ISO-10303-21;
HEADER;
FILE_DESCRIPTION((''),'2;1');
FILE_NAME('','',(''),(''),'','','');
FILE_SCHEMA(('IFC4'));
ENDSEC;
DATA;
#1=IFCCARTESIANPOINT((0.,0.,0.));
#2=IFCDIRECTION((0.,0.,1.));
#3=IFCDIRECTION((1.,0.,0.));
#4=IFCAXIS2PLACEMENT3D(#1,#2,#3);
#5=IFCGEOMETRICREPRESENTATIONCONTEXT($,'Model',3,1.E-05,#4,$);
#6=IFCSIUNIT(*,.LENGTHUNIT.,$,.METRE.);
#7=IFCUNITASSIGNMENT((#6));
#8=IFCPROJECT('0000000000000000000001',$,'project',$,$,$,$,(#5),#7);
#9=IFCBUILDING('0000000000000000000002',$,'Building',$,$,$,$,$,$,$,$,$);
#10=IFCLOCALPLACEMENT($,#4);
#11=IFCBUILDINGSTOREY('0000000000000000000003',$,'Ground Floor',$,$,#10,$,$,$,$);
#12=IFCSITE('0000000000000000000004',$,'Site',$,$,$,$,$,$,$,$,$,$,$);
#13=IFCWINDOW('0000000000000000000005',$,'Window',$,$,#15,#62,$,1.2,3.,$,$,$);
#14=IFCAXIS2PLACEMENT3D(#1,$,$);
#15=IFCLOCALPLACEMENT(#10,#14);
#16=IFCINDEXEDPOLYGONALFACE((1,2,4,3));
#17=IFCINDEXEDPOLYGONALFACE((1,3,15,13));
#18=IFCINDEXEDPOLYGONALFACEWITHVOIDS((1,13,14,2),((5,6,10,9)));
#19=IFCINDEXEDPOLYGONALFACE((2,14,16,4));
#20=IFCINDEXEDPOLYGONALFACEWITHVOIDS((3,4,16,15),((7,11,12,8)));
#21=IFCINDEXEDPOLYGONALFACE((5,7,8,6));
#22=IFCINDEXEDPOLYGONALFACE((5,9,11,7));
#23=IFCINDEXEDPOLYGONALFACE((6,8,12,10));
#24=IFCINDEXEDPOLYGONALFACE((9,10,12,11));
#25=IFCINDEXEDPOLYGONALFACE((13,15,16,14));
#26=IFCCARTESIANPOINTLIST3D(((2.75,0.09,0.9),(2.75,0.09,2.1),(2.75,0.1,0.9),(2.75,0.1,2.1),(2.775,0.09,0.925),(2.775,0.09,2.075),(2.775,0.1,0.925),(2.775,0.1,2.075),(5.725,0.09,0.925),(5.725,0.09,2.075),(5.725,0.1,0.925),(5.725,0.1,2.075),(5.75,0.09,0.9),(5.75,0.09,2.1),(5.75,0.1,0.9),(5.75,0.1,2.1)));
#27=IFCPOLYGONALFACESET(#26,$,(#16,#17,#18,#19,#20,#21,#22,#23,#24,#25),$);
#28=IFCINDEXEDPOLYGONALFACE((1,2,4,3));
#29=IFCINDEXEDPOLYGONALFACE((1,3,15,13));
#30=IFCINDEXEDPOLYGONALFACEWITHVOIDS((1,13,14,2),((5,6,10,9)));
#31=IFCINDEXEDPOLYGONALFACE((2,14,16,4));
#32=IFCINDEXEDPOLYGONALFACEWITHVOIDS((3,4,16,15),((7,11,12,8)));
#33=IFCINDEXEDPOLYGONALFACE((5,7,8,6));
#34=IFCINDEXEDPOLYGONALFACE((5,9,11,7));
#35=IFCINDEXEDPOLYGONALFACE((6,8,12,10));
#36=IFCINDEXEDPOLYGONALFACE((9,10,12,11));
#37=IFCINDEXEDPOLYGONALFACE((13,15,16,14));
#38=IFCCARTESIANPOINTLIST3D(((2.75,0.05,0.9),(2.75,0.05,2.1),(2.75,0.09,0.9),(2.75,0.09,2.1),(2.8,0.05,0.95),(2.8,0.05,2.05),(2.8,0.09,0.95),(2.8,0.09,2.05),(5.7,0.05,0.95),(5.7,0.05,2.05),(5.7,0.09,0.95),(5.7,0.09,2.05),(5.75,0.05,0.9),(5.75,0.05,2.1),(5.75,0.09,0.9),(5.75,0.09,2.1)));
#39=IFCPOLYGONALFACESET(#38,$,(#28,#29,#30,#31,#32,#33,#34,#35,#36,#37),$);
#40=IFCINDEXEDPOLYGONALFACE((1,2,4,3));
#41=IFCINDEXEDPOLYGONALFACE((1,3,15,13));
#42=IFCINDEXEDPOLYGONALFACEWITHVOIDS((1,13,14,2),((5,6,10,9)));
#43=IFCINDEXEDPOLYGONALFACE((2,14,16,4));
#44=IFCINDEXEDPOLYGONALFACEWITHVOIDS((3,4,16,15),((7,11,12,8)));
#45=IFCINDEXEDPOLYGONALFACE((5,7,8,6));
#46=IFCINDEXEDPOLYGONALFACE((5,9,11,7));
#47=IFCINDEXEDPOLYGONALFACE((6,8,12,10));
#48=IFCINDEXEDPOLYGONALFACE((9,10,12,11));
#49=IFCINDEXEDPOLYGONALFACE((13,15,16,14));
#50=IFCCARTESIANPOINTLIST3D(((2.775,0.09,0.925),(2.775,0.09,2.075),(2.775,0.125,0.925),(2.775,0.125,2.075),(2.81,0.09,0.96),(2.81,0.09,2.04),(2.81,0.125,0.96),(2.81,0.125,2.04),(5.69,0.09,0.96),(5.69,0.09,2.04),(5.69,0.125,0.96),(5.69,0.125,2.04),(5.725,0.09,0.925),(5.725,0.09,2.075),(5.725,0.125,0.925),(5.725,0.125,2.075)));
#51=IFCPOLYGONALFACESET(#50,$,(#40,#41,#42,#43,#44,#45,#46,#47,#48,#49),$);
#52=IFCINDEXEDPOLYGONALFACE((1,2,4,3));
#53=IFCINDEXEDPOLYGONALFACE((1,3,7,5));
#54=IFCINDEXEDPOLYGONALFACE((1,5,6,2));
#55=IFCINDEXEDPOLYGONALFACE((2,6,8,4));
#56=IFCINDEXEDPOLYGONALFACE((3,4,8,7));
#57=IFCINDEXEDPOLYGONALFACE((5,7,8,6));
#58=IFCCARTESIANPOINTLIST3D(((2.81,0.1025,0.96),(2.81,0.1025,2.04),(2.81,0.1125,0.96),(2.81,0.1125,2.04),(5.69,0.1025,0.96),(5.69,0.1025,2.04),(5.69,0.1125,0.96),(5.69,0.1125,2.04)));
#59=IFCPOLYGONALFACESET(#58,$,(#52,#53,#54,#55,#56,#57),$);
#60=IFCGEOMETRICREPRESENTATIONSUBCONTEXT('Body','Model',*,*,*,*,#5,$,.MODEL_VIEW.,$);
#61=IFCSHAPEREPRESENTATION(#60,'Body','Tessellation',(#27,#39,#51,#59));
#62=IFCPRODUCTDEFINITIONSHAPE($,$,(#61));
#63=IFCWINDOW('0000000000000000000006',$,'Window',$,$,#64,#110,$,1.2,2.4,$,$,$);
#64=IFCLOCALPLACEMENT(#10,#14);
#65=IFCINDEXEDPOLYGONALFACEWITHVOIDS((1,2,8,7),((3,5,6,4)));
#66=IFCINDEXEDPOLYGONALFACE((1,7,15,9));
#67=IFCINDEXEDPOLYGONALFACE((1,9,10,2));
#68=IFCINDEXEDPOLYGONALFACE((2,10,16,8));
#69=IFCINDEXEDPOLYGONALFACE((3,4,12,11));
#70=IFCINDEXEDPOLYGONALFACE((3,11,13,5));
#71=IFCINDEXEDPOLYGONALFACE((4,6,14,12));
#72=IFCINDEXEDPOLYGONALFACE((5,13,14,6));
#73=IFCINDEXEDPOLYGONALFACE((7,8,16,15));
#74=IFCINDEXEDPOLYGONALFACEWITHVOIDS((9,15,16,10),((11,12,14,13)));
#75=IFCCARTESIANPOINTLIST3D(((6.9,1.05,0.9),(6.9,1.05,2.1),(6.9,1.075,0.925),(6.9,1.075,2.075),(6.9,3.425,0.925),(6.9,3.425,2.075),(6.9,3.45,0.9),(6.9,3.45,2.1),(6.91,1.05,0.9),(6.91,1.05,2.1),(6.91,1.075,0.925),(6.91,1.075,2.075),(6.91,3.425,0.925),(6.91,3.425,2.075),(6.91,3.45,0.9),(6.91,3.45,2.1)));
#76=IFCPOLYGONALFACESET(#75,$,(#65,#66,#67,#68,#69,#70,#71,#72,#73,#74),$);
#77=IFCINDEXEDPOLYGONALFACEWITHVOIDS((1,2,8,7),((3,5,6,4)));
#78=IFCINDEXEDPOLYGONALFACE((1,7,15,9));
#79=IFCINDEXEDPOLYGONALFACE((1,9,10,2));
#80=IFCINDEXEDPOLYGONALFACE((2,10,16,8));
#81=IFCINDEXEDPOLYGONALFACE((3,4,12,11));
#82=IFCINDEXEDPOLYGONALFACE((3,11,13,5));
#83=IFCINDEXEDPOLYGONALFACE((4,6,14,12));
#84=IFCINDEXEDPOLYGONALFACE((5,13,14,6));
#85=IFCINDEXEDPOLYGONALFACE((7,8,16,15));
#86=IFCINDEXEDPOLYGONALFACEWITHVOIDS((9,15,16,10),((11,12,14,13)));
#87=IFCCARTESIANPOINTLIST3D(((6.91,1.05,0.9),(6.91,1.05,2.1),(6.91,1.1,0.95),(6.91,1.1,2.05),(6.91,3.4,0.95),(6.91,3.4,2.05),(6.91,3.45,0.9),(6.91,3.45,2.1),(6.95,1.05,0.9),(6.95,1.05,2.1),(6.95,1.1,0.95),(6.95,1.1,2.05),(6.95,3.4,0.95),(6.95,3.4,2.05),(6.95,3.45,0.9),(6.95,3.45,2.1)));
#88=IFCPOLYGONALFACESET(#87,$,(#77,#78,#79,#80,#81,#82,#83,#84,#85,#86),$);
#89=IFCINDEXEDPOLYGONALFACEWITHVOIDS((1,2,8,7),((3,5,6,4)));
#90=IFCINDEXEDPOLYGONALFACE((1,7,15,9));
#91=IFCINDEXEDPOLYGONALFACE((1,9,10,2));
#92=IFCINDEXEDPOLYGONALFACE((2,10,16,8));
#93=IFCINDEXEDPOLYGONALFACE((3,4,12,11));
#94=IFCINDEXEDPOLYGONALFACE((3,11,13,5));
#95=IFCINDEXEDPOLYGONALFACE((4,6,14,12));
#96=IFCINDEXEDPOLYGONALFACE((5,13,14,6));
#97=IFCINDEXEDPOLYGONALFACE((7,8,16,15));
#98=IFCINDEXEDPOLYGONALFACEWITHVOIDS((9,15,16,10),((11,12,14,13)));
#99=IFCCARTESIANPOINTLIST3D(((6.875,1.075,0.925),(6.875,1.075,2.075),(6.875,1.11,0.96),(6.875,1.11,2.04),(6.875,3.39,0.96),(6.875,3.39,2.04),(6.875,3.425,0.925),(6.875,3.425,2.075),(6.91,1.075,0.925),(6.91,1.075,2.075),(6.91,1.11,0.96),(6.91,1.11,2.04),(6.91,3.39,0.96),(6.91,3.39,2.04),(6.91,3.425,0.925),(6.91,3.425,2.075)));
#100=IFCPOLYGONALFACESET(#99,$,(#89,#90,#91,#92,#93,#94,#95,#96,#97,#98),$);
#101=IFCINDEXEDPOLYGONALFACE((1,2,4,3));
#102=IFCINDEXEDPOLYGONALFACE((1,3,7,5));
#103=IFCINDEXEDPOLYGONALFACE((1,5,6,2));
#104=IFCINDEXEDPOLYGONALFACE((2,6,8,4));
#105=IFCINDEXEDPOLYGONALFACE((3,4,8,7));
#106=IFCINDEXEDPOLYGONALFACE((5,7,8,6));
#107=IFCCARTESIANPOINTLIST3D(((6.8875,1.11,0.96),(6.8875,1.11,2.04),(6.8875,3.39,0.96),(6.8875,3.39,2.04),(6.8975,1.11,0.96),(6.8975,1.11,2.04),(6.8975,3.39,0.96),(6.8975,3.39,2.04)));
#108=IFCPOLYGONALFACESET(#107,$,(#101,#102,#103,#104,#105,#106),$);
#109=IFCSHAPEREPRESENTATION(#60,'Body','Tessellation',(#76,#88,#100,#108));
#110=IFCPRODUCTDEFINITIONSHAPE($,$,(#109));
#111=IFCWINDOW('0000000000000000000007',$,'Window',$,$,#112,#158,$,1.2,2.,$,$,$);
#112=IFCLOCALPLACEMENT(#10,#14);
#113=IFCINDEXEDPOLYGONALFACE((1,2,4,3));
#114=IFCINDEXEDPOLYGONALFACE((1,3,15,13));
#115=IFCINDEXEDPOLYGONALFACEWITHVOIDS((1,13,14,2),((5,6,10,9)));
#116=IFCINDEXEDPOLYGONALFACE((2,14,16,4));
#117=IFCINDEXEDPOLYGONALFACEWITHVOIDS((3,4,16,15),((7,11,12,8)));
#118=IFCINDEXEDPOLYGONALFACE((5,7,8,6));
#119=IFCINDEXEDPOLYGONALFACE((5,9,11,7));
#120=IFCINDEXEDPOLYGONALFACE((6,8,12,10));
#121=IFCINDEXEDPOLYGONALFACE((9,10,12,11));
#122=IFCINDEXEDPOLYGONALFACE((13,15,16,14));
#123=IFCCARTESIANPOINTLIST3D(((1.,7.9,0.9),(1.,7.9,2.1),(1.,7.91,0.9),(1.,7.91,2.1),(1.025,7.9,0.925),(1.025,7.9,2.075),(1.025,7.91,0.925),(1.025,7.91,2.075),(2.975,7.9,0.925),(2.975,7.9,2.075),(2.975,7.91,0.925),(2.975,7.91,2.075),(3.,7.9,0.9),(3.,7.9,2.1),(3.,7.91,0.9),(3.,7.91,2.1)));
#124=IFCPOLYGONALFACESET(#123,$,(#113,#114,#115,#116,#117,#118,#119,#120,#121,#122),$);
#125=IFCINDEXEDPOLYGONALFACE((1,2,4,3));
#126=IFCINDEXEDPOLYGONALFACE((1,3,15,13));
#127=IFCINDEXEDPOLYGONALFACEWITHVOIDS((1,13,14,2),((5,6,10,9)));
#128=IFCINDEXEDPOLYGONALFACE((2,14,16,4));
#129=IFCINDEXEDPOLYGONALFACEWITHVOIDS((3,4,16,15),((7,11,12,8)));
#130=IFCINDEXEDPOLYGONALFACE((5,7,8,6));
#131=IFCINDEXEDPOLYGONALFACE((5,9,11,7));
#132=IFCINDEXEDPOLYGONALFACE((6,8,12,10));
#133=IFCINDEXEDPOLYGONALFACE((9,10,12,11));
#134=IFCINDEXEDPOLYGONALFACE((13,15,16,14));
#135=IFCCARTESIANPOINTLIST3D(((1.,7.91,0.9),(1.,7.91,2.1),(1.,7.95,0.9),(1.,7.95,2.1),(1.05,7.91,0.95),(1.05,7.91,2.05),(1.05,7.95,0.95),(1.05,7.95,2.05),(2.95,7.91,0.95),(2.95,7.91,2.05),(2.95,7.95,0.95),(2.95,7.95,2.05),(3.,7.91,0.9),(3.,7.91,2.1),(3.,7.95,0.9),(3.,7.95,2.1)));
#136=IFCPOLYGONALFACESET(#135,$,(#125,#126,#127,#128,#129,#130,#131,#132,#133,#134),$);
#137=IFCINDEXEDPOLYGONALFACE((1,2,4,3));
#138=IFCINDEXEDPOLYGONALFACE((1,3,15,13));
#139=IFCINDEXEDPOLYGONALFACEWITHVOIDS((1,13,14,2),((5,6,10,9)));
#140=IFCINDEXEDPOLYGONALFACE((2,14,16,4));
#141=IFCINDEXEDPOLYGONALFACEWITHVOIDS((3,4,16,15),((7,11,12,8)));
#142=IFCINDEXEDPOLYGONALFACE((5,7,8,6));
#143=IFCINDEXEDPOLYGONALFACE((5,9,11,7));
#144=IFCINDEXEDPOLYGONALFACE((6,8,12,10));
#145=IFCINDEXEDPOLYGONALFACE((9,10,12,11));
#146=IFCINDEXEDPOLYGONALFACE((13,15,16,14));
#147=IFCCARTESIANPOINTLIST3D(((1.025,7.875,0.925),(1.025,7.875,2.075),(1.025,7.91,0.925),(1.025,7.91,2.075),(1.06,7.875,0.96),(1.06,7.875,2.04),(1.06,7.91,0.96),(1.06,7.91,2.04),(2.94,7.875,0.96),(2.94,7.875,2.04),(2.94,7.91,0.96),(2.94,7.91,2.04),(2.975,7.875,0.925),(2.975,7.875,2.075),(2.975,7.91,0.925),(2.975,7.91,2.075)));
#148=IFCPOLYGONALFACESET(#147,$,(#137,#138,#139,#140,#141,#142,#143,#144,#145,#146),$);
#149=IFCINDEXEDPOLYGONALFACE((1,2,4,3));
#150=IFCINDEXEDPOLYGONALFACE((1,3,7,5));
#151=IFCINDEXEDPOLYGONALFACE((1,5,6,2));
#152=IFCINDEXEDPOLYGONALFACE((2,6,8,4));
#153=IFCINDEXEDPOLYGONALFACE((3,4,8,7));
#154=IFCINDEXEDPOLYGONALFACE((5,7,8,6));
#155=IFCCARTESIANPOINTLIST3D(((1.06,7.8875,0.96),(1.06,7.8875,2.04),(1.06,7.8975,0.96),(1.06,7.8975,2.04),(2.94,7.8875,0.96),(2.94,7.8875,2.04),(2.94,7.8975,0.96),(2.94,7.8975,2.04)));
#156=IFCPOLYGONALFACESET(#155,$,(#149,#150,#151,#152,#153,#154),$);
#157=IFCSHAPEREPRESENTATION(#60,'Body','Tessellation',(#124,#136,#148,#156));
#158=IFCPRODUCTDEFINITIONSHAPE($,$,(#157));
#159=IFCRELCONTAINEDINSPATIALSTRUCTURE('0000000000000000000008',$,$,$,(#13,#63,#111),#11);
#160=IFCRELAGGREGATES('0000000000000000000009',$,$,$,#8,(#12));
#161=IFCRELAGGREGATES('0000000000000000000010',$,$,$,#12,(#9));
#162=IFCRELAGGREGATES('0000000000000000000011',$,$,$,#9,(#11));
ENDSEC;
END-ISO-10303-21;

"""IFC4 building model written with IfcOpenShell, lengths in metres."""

from ifc_helpers import new_model, si_unit, frame, origin_with_axes, place, context, subcontext, project, spatial, line, indexed_curve, outline, extrude, element, save


model = new_model("IFC4")

# Units and contexts
model_context = context("Model", 3, precision=1e-05, world=origin_with_axes())
body_context = subcontext(model_context, "Body", "Model", "MODEL_VIEW")
ifc_project = project(units=[si_unit("LENGTHUNIT", "METRE")], contexts=[model_context])

# Site, building, storey
site = spatial("IfcSite", under=ifc_project, Name="Site")
building = spatial("IfcBuilding", under=site, Name="Building")
storey_placement = place(None, origin_with_axes())
storey = spatial("IfcBuildingStorey", under=building, at=storey_placement, Name="Ground Floor")

# Windows
window_1_placement = place(storey_placement, frame((2.75, 0.0, 0.9), z_axis=(0.0, 0.0, 1.0), x_axis=(1.0, 0.0, 0.0)))
element("IfcWindow", 1, at=window_1_placement, inside=storey, Name="Window", OverallHeight=1.2, OverallWidth=3.0, context=body_context, shape_type="SweptSolid", body=[
    extrude(outline(indexed_curve([(0.0, 0.0), (3.0, 0.0), (3.0, 1.2), (0.0, 1.2)], segments=[line(1, 2, 3, 4, 1)]), holes=[indexed_curve([(0.025, 0.025), (2.975, 0.025), (2.975, 1.175), (0.025, 1.175)], segments=[line(1, 2, 3, 4, 1)])]), frame((0.0, 0.09, 0.0), z_axis=(0.0, -1.0, 0.0), x_axis=(1.0, 0.0, 0.0)), (0.0, 0.0, -1.0), 0.01),
    extrude(outline(indexed_curve([(0.0, 0.0), (3.0, 0.0), (3.0, 1.2), (0.0, 1.2)], segments=[line(1, 2, 3, 4, 1)]), holes=[indexed_curve([(0.05, 0.05), (2.95, 0.05), (2.95, 1.15), (0.05, 1.15)], segments=[line(1, 2, 3, 4, 1)])]), frame((0.0, 0.05, 0.0), z_axis=(0.0, -1.0, 0.0), x_axis=(1.0, 0.0, 0.0)), (0.0, 0.0, -1.0), 0.04),
    extrude(outline(indexed_curve([(0.0, 0.0), (2.95, 0.0), (2.95, 1.15), (0.0, 1.15)], segments=[line(1, 2, 3, 4, 1)]), holes=[indexed_curve([(0.035, 0.035), (2.915, 0.035), (2.915, 1.115), (0.035, 1.115)], segments=[line(1, 2, 3, 4, 1)])]), frame((0.025, 0.09, 0.025), z_axis=(0.0, -1.0, 0.0), x_axis=(1.0, 0.0, 0.0)), (0.0, 0.0, -1.0), 0.035),
    extrude(outline(indexed_curve([(0.035, 0.035), (2.915, 0.035), (2.915, 1.115), (0.035, 1.115)], segments=[line(1, 2, 3, 4, 1)])), frame((0.025, 0.1025, 0.025), z_axis=(0.0, -1.0, 0.0), x_axis=(1.0, 0.0, 0.0)), (0.0, 0.0, -1.0), 0.01),
])
window_2_placement = place(storey_placement, frame((7.0, 1.05, 0.9), z_axis=(0.0, 0.0, 1.0), x_axis=(0.0, 1.0, 0.0)))
element("IfcWindow", 2, at=window_2_placement, inside=storey, Name="Window", OverallHeight=1.2, OverallWidth=2.4, context=body_context, shape_type="SweptSolid", body=[
    extrude(outline(indexed_curve([(0.0, 0.0), (2.4, 0.0), (2.4, 1.2), (0.0, 1.2)], segments=[line(1, 2, 3, 4, 1)]), holes=[indexed_curve([(0.025, 0.025), (2.375, 0.025), (2.375, 1.175), (0.025, 1.175)], segments=[line(1, 2, 3, 4, 1)])]), frame((0.0, 0.09, 0.0), z_axis=(0.0, -1.0, 0.0), x_axis=(1.0, 0.0, 0.0)), (0.0, 0.0, -1.0), 0.01),
    extrude(outline(indexed_curve([(0.0, 0.0), (2.4, 0.0), (2.4, 1.2), (0.0, 1.2)], segments=[line(1, 2, 3, 4, 1)]), holes=[indexed_curve([(0.05, 0.05), (2.35, 0.05), (2.35, 1.15), (0.05, 1.15)], segments=[line(1, 2, 3, 4, 1)])]), frame((0.0, 0.05, 0.0), z_axis=(0.0, -1.0, 0.0), x_axis=(1.0, 0.0, 0.0)), (0.0, 0.0, -1.0), 0.04),
    extrude(outline(indexed_curve([(0.0, 0.0), (2.35, 0.0), (2.35, 1.15), (0.0, 1.15)], segments=[line(1, 2, 3, 4, 1)]), holes=[indexed_curve([(0.035, 0.035), (2.315, 0.035), (2.315, 1.115), (0.035, 1.115)], segments=[line(1, 2, 3, 4, 1)])]), frame((0.025, 0.09, 0.025), z_axis=(0.0, -1.0, 0.0), x_axis=(1.0, 0.0, 0.0)), (0.0, 0.0, -1.0), 0.035),
    extrude(outline(indexed_curve([(0.035, 0.035), (2.315, 0.035), (2.315, 1.115), (0.035, 1.115)], segments=[line(1, 2, 3, 4, 1)])), frame((0.025, 0.1025, 0.025), z_axis=(0.0, -1.0, 0.0), x_axis=(1.0, 0.0, 0.0)), (0.0, 0.0, -1.0), 0.01),
])
window_3_placement = place(storey_placement, frame((3.0, 8.0, 0.9), z_axis=(0.0, 0.0, 1.0), x_axis=(-1.0, 0.0, 0.0)))
element("IfcWindow", 3, at=window_3_placement, inside=storey, Name="Window", OverallHeight=1.2, OverallWidth=2.0, context=body_context, shape_type="SweptSolid", body=[
    extrude(outline(indexed_curve([(0.0, 0.0), (2.0, 0.0), (2.0, 1.2), (0.0, 1.2)], segments=[line(1, 2, 3, 4, 1)]), holes=[indexed_curve([(0.025, 0.025), (1.975, 0.025), (1.975, 1.175), (0.025, 1.175)], segments=[line(1, 2, 3, 4, 1)])]), frame((0.0, 0.09, 0.0), z_axis=(0.0, -1.0, 0.0), x_axis=(1.0, 0.0, 0.0)), (0.0, 0.0, -1.0), 0.01),
    extrude(outline(indexed_curve([(0.0, 0.0), (2.0, 0.0), (2.0, 1.2), (0.0, 1.2)], segments=[line(1, 2, 3, 4, 1)]), holes=[indexed_curve([(0.05, 0.05), (1.95, 0.05), (1.95, 1.15), (0.05, 1.15)], segments=[line(1, 2, 3, 4, 1)])]), frame((0.0, 0.05, 0.0), z_axis=(0.0, -1.0, 0.0), x_axis=(1.0, 0.0, 0.0)), (0.0, 0.0, -1.0), 0.04),
    extrude(outline(indexed_curve([(0.0, 0.0), (1.95, 0.0), (1.95, 1.15), (0.0, 1.15)], segments=[line(1, 2, 3, 4, 1)]), holes=[indexed_curve([(0.035, 0.035), (1.915, 0.035), (1.915, 1.115), (0.035, 1.115)], segments=[line(1, 2, 3, 4, 1)])]), frame((0.025, 0.09, 0.025), z_axis=(0.0, -1.0, 0.0), x_axis=(1.0, 0.0, 0.0)), (0.0, 0.0, -1.0), 0.035),
    extrude(outline(indexed_curve([(0.035, 0.035), (1.915, 0.035), (1.915, 1.115), (0.035, 1.115)], segments=[line(1, 2, 3, 4, 1)])), frame((0.025, 0.1025, 0.025), z_axis=(0.0, -1.0, 0.0), x_axis=(1.0, 0.0, 0.0)), (0.0, 0.0, -1.0), 0.01),
])

save(model, "model.ifc")
